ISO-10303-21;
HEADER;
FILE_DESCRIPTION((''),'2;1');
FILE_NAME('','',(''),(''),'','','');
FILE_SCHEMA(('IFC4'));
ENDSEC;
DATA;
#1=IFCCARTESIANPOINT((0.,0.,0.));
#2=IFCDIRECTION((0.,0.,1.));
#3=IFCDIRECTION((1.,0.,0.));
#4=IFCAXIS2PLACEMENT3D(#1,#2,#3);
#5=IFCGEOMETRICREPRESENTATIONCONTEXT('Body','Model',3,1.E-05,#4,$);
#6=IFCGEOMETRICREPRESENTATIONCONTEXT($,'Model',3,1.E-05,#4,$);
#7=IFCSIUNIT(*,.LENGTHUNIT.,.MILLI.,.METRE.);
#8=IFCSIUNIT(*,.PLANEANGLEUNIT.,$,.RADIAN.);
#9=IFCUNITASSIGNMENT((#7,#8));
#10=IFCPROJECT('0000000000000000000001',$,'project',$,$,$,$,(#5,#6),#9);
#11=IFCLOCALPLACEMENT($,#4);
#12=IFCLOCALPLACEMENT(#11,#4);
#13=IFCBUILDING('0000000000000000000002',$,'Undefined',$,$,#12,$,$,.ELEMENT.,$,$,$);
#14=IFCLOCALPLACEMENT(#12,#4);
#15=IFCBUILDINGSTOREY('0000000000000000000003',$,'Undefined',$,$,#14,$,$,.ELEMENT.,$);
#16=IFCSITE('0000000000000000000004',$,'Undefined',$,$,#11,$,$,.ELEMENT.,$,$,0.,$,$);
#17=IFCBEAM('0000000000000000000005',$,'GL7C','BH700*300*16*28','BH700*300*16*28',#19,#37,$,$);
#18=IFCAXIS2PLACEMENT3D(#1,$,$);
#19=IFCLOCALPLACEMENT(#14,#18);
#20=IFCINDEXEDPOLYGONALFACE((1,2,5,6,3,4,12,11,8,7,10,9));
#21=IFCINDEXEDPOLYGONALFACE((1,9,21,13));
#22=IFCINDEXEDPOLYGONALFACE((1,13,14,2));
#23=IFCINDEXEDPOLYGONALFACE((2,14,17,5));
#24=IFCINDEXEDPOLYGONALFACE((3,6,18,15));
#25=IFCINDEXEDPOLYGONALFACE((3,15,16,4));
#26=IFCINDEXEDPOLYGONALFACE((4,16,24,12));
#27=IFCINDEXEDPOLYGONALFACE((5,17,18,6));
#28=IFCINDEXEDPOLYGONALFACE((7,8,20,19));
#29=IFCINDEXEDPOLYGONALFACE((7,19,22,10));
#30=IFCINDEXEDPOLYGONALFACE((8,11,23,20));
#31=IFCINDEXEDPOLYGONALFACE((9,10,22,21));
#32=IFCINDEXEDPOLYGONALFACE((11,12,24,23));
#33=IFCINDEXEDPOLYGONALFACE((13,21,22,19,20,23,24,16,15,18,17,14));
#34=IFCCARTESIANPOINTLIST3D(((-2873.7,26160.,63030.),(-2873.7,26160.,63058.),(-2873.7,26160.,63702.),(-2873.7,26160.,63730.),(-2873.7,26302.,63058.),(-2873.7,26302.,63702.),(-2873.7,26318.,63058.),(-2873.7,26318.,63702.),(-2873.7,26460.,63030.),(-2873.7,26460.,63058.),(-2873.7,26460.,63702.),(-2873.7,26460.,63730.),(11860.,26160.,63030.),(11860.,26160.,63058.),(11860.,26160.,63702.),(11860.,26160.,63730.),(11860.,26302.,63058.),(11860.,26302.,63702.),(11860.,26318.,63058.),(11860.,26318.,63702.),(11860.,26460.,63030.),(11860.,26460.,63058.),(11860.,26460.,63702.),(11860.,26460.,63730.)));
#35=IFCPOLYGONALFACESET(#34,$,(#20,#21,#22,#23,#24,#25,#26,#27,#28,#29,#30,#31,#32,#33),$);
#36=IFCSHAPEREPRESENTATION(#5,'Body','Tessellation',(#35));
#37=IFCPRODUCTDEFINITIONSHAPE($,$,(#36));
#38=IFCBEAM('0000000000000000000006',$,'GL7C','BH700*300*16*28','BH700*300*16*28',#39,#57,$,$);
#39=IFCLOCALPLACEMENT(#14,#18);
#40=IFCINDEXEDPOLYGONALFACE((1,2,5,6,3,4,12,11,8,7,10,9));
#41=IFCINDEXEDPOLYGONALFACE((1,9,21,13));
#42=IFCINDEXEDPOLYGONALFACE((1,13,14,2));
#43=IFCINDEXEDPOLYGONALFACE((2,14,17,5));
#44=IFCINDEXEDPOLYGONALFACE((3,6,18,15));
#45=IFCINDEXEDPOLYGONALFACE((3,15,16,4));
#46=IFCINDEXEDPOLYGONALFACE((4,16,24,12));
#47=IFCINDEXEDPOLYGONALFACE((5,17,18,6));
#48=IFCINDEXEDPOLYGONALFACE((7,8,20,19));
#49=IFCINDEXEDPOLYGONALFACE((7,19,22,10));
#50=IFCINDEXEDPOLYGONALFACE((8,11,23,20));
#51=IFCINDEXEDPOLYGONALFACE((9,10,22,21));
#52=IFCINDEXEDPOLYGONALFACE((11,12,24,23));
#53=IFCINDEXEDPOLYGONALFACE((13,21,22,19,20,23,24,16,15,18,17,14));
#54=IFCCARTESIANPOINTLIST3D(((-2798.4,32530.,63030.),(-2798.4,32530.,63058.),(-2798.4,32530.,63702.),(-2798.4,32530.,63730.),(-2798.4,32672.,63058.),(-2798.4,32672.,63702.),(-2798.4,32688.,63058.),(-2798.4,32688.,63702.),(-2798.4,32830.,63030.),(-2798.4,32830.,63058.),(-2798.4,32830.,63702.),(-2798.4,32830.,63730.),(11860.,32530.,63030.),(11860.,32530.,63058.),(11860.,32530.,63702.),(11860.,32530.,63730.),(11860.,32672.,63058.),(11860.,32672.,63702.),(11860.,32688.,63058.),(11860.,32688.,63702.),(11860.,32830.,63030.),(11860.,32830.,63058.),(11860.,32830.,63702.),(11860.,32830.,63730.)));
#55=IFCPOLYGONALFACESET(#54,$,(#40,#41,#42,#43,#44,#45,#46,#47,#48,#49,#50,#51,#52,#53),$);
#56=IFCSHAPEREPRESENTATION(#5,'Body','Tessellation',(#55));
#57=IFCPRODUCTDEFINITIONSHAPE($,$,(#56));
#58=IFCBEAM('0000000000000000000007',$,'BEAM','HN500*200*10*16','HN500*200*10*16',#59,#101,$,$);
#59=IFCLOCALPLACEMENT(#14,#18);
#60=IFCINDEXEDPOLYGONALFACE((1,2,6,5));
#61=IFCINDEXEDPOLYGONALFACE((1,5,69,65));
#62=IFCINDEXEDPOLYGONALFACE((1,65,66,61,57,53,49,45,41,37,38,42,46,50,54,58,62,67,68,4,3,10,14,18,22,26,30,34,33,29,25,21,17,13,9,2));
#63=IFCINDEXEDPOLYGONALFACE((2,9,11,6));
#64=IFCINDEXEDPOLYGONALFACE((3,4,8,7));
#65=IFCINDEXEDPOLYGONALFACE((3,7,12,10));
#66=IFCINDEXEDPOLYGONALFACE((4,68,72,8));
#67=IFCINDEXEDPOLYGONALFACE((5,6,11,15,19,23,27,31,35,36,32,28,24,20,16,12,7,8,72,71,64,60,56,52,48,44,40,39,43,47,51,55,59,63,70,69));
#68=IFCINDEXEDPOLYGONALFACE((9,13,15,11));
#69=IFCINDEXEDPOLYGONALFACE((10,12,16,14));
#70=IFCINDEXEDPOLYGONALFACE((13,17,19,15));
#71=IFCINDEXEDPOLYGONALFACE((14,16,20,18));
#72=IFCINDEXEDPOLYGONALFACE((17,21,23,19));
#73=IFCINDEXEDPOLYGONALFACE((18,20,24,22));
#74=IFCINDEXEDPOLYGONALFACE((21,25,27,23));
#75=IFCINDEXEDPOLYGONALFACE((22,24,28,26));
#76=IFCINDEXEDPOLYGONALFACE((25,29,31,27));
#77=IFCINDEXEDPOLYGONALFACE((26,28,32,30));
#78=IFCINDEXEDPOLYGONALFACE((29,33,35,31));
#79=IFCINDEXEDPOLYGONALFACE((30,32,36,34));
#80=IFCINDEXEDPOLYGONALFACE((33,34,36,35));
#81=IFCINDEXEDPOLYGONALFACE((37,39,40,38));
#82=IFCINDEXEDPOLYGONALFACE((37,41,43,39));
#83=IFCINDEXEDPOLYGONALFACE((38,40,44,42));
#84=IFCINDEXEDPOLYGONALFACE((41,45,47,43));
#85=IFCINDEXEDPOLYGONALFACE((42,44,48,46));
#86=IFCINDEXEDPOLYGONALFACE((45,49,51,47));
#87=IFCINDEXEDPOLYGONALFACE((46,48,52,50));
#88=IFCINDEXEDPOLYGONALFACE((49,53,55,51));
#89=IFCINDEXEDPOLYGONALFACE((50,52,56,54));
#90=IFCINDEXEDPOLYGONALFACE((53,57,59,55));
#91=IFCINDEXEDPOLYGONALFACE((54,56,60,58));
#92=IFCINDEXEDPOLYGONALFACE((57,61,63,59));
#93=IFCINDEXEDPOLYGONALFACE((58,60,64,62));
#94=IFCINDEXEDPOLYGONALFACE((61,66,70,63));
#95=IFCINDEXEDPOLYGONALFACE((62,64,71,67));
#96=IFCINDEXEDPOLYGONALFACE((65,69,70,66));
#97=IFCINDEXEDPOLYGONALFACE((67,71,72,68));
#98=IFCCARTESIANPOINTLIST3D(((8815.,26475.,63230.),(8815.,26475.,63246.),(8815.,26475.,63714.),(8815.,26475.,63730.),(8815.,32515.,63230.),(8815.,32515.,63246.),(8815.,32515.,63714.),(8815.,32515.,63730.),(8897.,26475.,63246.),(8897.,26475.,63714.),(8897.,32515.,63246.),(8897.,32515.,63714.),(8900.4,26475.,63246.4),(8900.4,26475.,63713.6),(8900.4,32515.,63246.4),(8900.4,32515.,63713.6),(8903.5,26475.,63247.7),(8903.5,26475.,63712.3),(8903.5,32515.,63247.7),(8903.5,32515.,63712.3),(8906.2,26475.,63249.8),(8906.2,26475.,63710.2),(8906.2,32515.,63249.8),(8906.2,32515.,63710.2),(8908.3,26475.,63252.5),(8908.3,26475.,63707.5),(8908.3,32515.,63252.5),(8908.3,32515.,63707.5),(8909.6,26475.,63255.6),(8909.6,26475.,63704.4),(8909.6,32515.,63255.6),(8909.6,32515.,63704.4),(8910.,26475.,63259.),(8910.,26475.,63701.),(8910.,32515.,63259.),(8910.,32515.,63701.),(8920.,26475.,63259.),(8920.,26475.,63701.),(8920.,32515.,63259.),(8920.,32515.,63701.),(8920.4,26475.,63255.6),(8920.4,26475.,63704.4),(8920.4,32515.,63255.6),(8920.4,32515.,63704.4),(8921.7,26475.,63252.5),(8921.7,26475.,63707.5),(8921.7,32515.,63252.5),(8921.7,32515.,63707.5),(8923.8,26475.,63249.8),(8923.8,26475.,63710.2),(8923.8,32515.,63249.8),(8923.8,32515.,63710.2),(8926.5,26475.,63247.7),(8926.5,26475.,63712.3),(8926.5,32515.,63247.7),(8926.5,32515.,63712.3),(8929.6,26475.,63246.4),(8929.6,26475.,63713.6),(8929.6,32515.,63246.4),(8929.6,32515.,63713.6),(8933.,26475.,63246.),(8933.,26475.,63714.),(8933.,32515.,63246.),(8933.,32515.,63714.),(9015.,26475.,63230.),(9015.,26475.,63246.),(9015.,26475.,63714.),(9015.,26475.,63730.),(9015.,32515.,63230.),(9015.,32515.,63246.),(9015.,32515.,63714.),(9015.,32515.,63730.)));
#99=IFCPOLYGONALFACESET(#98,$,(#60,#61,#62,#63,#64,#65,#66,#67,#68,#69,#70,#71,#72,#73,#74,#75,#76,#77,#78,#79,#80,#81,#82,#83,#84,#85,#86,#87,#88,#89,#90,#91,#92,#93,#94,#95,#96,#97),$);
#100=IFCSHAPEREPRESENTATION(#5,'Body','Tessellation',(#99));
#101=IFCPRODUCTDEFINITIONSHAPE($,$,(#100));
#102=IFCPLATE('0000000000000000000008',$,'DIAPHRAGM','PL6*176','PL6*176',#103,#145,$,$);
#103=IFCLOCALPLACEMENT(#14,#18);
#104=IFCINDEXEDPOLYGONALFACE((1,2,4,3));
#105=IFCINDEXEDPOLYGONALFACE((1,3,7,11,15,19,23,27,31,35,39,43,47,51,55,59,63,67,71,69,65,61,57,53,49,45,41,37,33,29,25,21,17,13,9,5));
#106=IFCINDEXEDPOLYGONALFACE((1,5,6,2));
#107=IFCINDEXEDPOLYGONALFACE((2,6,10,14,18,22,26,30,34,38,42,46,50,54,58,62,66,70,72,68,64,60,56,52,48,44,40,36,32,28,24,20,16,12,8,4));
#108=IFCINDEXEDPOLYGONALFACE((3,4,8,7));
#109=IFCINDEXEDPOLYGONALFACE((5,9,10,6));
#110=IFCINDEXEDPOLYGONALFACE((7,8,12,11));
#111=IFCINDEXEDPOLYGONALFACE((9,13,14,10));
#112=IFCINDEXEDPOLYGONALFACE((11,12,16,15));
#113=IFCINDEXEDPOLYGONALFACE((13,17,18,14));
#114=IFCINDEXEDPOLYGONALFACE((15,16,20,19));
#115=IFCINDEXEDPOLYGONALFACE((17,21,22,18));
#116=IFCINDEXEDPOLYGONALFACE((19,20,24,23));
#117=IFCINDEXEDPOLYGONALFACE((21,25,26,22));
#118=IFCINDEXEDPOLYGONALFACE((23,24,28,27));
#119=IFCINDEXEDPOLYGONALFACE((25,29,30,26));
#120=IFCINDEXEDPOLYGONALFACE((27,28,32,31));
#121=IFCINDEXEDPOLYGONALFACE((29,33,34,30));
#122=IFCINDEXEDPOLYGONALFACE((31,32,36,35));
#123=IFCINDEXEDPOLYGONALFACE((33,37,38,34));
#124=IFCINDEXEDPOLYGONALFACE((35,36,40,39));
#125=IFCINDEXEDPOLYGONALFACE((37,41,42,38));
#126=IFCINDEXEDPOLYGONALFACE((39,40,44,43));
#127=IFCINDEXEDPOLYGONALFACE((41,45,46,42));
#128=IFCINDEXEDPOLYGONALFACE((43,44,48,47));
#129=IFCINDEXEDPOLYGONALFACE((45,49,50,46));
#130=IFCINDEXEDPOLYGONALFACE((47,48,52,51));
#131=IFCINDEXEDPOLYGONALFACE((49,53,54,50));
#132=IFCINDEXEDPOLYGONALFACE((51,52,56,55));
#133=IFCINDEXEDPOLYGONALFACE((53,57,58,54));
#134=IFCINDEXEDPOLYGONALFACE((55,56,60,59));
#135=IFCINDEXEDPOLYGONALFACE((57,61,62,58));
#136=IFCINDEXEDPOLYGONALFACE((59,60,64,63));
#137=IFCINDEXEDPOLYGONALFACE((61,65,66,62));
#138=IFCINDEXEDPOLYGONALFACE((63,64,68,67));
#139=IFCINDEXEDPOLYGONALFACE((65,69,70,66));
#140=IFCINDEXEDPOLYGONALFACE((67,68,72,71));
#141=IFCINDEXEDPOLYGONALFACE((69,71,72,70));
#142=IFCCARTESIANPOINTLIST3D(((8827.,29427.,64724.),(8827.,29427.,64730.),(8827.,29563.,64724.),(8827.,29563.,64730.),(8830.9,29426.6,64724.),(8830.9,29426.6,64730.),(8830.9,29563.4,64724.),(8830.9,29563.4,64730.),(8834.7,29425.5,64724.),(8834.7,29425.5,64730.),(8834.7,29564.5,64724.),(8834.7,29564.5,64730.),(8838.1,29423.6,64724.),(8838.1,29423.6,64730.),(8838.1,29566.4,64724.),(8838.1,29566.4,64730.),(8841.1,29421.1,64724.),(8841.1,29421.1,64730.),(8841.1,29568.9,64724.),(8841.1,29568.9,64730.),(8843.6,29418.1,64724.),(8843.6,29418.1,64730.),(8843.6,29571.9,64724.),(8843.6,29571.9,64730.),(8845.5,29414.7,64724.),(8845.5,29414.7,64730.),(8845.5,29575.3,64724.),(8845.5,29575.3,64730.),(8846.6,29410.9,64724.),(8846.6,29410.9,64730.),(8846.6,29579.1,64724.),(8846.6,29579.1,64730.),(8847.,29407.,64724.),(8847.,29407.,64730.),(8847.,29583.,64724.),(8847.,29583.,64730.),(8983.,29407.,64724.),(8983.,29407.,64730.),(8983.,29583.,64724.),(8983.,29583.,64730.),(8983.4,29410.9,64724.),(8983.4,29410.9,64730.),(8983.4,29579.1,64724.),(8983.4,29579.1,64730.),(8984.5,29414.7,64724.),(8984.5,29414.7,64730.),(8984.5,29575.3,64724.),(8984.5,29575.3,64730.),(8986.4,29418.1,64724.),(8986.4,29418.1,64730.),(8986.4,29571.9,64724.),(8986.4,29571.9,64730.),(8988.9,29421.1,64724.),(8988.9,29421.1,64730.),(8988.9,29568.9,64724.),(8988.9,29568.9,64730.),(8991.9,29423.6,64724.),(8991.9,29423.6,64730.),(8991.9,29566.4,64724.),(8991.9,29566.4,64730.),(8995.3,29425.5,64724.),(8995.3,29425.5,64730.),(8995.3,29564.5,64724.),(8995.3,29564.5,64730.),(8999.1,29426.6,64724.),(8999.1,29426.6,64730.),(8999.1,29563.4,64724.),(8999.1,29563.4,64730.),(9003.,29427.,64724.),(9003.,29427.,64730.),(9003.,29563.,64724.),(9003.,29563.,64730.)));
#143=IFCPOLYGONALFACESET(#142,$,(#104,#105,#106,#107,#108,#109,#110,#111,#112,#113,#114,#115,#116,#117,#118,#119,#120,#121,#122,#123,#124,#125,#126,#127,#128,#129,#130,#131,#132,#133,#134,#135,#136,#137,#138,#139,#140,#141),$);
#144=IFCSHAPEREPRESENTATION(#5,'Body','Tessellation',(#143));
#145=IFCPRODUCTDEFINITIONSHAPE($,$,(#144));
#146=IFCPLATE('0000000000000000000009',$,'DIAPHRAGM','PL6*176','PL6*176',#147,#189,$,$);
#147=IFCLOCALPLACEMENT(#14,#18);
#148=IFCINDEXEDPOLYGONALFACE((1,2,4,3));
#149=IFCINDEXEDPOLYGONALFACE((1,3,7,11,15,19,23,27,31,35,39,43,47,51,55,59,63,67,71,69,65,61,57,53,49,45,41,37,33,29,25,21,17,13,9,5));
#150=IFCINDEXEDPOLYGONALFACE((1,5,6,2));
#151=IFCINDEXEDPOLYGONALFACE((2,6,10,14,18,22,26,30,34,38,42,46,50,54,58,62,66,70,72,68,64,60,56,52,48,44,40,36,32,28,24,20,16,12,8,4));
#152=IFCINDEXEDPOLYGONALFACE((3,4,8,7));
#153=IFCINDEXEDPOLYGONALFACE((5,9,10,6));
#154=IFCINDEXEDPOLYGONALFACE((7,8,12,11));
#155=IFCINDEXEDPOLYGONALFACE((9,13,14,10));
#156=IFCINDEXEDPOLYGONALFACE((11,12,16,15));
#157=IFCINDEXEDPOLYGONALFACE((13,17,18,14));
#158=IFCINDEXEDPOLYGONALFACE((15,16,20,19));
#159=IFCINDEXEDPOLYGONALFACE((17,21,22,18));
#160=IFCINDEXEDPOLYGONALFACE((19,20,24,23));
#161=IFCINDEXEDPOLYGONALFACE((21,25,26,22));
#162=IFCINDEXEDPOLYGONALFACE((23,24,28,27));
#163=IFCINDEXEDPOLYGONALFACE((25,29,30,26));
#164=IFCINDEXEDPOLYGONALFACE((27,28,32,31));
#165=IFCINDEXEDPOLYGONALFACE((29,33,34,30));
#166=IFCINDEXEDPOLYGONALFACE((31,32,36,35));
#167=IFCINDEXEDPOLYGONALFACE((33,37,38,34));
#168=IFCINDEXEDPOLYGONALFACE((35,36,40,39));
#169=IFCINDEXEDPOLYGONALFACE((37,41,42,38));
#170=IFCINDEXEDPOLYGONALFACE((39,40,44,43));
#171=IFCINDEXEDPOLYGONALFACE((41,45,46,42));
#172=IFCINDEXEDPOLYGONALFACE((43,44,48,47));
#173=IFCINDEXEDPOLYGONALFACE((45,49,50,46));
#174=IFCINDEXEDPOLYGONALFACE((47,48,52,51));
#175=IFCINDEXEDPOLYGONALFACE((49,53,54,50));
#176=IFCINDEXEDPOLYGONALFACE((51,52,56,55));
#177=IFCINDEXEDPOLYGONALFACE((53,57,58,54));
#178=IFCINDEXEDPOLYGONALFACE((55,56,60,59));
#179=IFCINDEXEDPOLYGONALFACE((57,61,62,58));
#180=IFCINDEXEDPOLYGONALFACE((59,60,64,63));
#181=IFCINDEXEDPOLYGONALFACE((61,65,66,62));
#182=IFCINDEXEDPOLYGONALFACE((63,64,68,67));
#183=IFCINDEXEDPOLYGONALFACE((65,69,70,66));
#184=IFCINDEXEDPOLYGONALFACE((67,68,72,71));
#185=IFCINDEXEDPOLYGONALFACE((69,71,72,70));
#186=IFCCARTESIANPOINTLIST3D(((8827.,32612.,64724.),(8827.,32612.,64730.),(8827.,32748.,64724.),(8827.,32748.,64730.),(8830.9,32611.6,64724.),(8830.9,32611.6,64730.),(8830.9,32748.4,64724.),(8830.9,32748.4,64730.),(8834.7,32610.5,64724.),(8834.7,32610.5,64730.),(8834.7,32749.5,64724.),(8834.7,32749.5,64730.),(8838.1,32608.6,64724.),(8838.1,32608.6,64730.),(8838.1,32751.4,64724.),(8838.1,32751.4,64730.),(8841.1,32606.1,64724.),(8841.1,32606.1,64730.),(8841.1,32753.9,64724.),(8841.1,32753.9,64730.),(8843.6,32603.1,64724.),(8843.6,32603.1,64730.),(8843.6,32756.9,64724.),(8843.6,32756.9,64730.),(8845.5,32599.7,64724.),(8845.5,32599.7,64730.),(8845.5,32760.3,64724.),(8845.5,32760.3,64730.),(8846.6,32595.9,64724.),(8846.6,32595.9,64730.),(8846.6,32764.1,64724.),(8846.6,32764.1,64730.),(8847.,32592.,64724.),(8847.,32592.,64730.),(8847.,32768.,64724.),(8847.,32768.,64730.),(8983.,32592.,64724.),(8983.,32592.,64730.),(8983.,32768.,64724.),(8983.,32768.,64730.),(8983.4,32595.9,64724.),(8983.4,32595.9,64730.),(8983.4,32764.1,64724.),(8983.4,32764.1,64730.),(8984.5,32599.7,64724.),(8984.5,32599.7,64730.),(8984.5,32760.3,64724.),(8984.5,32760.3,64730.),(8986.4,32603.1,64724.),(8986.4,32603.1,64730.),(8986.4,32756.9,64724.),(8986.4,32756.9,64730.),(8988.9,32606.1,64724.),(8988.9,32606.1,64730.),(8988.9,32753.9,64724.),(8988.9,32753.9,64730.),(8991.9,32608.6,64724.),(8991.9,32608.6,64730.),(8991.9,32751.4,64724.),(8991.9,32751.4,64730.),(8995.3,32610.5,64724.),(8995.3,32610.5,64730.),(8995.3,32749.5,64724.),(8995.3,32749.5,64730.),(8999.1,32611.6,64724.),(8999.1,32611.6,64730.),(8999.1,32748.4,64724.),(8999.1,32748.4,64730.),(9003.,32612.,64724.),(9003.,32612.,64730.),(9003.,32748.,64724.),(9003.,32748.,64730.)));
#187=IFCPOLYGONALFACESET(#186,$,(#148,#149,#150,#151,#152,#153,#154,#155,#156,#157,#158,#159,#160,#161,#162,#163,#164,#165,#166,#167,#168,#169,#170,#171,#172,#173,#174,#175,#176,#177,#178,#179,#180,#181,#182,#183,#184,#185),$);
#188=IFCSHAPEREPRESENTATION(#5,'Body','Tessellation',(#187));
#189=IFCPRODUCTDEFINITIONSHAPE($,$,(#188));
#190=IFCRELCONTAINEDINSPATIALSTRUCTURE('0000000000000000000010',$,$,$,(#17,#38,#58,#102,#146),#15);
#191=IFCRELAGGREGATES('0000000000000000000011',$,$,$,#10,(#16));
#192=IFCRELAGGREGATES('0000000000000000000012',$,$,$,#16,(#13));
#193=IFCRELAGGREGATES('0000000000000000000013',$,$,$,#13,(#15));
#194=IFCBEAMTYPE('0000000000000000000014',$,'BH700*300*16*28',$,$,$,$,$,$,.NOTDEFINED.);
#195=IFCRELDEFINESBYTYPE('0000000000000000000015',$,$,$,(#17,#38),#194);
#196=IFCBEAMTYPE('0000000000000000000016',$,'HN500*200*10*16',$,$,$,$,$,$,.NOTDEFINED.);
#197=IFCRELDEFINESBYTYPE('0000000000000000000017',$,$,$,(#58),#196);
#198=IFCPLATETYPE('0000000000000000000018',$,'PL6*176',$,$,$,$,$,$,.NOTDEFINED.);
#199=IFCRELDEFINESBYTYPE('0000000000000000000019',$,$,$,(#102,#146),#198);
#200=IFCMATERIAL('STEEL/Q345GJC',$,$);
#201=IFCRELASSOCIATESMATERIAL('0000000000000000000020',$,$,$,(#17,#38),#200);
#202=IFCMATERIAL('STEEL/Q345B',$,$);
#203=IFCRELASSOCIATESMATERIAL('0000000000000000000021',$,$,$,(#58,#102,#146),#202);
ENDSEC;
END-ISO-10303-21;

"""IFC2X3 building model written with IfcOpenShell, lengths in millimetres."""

from ifc_helpers import new_model, si_unit, frame, origin_with_axes, origin_2d_with_axis, place, context, project, spatial, polyline, i_section, outline, extrude, material, type_object, element, save


model = new_model("IFC2X3")

# Units and contexts
model_context_1 = context("Model", 3, precision=1e-05, world=origin_with_axes(), identifier="Body")
model_context_2 = context("Model", 3, precision=1e-05, world=origin_with_axes())
ifc_project = project(units=[si_unit("LENGTHUNIT", "METRE", prefix="MILLI"), si_unit("PLANEANGLEUNIT", "RADIAN")], contexts=[model_context_1, model_context_2])

# Site, building, storey
site_placement = place(None, origin_with_axes())
site = spatial("IfcSite", under=ifc_project, at=site_placement, Name="Undefined", CompositionType="ELEMENT", RefElevation=0.0)
building_placement = place(site_placement, origin_with_axes())
building = spatial("IfcBuilding", under=site, at=building_placement, Name="Undefined", CompositionType="ELEMENT")
storey_placement = place(building_placement, origin_with_axes())
storey = spatial("IfcBuildingStorey", under=building, at=storey_placement, Name="Undefined", CompositionType="ELEMENT")

# Shared definitions
ifc_material_1 = material(Name="STEEL/Q345B")

# Beams
ifc_material_2 = material(Name="STEEL/Q345GJC")
beam_type_1 = type_object("IfcBeamType", Name="BH700*300*16*28", PredefinedType="NOTDEFINED")
beam_1_placement = place(storey_placement, frame((11880.0, 26310.0, 63380.0), z_axis=(0.0, 0.0, 1.0), x_axis=(-1.0, 0.0, 0.0)))
element("IfcBeam", 1, at=beam_1_placement, inside=storey, type_object=beam_type_1, material=ifc_material_2, Name="GL7C", Description="BH700*300*16*28", ObjectType="BH700*300*16*28", context=model_context_1, shape_type="SweptSolid", body=[
    extrude(i_section(OverallWidth=300.0, OverallDepth=700.0, WebThickness=16.0, FlangeThickness=28.0, at=origin_2d_with_axis()), frame((14753.7, 0.0, 0.0), z_axis=(-1.0, 0.0, 0.0), x_axis=(0.0, -1.0, 0.0)), (0.0, 0.0, 1.0), 14733.7),
])
beam_2_placement = place(storey_placement, frame((11880.0, 32680.0, 63380.0), z_axis=(0.0, 0.0, 1.0), x_axis=(-1.0, 0.0, 0.0)))
element("IfcBeam", 2, at=beam_2_placement, inside=storey, type_object=beam_type_1, material=ifc_material_2, Name="GL7C", Description="BH700*300*16*28", ObjectType="BH700*300*16*28", context=model_context_1, shape_type="SweptSolid", body=[
    extrude(i_section(OverallWidth=300.0, OverallDepth=700.0, WebThickness=16.0, FlangeThickness=28.0, at=origin_2d_with_axis()), frame((14678.4, 0.0, 0.0), z_axis=(-1.0, 0.0, 0.0), x_axis=(0.0, -1.0, 0.0)), (0.0, 0.0, 1.0), 14658.4),
])
beam_type_2 = type_object("IfcBeamType", Name="HN500*200*10*16", PredefinedType="NOTDEFINED")
beam_3_placement = place(storey_placement, frame((8915.0, 26310.0, 63480.0), z_axis=(0.0, 0.0, 1.0), x_axis=(0.0, 1.0, 0.0)))
element("IfcBeam", 3, at=beam_3_placement, inside=storey, type_object=beam_type_2, material=ifc_material_1, Name="BEAM", Description="HN500*200*10*16", ObjectType="HN500*200*10*16", context=model_context_1, shape_type="SweptSolid", body=[
    extrude(i_section(OverallWidth=200.0, OverallDepth=500.0, WebThickness=10.0, FlangeThickness=16.0, FilletRadius=13.0, at=origin_2d_with_axis()), frame((6205.0, 0.0, 0.0), z_axis=(-1.0, 0.0, 0.0), x_axis=(0.0, -1.0, 0.0)), (0.0, 0.0, 1.0), 6040.0),
])

# Plates
plate_type_1 = type_object("IfcPlateType", Name="PL6*176", PredefinedType="NOTDEFINED")
for number, where, z_axis, x_axis, name in (
    (4, (9003.0, 29407.0, 64727.0), (0.0, 0.0, -1.0), (-1.0, 0.0, 0.0), "DIAPHRAGM"),
    (5, (9003.0, 32592.0, 64727.0), (0.0, 0.0, -1.0), (-1.0, 0.0, 0.0), "DIAPHRAGM"),
):
    element("IfcPlate", number, at=place(storey_placement, frame(where, z_axis=z_axis, x_axis=x_axis)), inside=storey, type_object=plate_type_1, material=ifc_material_1, Name=name, Description="PL6*176", ObjectType="PL6*176", context=model_context_1, shape_type="SweptSolid", body=[
        extrude(outline(polyline([(0.0, 20.0), (3.9, 19.6), (7.7, 18.5), (11.1, 16.6), (14.1, 14.1), (16.6, 11.1), (18.5, 7.7), (19.6, 3.9), (20.0, 0.0), (156.0, 0.0), (156.4, 3.9), (157.5, 7.7), (159.4, 11.1), (161.9, 14.1), (164.9, 16.6), (168.3, 18.5), (172.1, 19.6), (176.0, 20.0), (176.0, 156.0), (172.1, 156.4), (168.3, 157.5), (164.9, 159.4), (161.9, 161.9), (159.4, 164.9), (157.5, 168.3), (156.4, 172.1), (156.0, 176.0), (20.0, 176.0), (19.6, 172.1), (18.5, 168.3), (16.6, 164.9), (14.1, 161.9), (11.1, 159.4), (7.7, 157.5), (3.9, 156.4), (0.0, 156.0), (0.0, 20.0)])), frame((0.0, 0.0, -3.0), z_axis=(0.0, 0.0, 1.0), x_axis=(1.0, 0.0, 0.0)), (0.0, 0.0, 1.0), 6.0),
    ])

save(model, "model.ifc")
